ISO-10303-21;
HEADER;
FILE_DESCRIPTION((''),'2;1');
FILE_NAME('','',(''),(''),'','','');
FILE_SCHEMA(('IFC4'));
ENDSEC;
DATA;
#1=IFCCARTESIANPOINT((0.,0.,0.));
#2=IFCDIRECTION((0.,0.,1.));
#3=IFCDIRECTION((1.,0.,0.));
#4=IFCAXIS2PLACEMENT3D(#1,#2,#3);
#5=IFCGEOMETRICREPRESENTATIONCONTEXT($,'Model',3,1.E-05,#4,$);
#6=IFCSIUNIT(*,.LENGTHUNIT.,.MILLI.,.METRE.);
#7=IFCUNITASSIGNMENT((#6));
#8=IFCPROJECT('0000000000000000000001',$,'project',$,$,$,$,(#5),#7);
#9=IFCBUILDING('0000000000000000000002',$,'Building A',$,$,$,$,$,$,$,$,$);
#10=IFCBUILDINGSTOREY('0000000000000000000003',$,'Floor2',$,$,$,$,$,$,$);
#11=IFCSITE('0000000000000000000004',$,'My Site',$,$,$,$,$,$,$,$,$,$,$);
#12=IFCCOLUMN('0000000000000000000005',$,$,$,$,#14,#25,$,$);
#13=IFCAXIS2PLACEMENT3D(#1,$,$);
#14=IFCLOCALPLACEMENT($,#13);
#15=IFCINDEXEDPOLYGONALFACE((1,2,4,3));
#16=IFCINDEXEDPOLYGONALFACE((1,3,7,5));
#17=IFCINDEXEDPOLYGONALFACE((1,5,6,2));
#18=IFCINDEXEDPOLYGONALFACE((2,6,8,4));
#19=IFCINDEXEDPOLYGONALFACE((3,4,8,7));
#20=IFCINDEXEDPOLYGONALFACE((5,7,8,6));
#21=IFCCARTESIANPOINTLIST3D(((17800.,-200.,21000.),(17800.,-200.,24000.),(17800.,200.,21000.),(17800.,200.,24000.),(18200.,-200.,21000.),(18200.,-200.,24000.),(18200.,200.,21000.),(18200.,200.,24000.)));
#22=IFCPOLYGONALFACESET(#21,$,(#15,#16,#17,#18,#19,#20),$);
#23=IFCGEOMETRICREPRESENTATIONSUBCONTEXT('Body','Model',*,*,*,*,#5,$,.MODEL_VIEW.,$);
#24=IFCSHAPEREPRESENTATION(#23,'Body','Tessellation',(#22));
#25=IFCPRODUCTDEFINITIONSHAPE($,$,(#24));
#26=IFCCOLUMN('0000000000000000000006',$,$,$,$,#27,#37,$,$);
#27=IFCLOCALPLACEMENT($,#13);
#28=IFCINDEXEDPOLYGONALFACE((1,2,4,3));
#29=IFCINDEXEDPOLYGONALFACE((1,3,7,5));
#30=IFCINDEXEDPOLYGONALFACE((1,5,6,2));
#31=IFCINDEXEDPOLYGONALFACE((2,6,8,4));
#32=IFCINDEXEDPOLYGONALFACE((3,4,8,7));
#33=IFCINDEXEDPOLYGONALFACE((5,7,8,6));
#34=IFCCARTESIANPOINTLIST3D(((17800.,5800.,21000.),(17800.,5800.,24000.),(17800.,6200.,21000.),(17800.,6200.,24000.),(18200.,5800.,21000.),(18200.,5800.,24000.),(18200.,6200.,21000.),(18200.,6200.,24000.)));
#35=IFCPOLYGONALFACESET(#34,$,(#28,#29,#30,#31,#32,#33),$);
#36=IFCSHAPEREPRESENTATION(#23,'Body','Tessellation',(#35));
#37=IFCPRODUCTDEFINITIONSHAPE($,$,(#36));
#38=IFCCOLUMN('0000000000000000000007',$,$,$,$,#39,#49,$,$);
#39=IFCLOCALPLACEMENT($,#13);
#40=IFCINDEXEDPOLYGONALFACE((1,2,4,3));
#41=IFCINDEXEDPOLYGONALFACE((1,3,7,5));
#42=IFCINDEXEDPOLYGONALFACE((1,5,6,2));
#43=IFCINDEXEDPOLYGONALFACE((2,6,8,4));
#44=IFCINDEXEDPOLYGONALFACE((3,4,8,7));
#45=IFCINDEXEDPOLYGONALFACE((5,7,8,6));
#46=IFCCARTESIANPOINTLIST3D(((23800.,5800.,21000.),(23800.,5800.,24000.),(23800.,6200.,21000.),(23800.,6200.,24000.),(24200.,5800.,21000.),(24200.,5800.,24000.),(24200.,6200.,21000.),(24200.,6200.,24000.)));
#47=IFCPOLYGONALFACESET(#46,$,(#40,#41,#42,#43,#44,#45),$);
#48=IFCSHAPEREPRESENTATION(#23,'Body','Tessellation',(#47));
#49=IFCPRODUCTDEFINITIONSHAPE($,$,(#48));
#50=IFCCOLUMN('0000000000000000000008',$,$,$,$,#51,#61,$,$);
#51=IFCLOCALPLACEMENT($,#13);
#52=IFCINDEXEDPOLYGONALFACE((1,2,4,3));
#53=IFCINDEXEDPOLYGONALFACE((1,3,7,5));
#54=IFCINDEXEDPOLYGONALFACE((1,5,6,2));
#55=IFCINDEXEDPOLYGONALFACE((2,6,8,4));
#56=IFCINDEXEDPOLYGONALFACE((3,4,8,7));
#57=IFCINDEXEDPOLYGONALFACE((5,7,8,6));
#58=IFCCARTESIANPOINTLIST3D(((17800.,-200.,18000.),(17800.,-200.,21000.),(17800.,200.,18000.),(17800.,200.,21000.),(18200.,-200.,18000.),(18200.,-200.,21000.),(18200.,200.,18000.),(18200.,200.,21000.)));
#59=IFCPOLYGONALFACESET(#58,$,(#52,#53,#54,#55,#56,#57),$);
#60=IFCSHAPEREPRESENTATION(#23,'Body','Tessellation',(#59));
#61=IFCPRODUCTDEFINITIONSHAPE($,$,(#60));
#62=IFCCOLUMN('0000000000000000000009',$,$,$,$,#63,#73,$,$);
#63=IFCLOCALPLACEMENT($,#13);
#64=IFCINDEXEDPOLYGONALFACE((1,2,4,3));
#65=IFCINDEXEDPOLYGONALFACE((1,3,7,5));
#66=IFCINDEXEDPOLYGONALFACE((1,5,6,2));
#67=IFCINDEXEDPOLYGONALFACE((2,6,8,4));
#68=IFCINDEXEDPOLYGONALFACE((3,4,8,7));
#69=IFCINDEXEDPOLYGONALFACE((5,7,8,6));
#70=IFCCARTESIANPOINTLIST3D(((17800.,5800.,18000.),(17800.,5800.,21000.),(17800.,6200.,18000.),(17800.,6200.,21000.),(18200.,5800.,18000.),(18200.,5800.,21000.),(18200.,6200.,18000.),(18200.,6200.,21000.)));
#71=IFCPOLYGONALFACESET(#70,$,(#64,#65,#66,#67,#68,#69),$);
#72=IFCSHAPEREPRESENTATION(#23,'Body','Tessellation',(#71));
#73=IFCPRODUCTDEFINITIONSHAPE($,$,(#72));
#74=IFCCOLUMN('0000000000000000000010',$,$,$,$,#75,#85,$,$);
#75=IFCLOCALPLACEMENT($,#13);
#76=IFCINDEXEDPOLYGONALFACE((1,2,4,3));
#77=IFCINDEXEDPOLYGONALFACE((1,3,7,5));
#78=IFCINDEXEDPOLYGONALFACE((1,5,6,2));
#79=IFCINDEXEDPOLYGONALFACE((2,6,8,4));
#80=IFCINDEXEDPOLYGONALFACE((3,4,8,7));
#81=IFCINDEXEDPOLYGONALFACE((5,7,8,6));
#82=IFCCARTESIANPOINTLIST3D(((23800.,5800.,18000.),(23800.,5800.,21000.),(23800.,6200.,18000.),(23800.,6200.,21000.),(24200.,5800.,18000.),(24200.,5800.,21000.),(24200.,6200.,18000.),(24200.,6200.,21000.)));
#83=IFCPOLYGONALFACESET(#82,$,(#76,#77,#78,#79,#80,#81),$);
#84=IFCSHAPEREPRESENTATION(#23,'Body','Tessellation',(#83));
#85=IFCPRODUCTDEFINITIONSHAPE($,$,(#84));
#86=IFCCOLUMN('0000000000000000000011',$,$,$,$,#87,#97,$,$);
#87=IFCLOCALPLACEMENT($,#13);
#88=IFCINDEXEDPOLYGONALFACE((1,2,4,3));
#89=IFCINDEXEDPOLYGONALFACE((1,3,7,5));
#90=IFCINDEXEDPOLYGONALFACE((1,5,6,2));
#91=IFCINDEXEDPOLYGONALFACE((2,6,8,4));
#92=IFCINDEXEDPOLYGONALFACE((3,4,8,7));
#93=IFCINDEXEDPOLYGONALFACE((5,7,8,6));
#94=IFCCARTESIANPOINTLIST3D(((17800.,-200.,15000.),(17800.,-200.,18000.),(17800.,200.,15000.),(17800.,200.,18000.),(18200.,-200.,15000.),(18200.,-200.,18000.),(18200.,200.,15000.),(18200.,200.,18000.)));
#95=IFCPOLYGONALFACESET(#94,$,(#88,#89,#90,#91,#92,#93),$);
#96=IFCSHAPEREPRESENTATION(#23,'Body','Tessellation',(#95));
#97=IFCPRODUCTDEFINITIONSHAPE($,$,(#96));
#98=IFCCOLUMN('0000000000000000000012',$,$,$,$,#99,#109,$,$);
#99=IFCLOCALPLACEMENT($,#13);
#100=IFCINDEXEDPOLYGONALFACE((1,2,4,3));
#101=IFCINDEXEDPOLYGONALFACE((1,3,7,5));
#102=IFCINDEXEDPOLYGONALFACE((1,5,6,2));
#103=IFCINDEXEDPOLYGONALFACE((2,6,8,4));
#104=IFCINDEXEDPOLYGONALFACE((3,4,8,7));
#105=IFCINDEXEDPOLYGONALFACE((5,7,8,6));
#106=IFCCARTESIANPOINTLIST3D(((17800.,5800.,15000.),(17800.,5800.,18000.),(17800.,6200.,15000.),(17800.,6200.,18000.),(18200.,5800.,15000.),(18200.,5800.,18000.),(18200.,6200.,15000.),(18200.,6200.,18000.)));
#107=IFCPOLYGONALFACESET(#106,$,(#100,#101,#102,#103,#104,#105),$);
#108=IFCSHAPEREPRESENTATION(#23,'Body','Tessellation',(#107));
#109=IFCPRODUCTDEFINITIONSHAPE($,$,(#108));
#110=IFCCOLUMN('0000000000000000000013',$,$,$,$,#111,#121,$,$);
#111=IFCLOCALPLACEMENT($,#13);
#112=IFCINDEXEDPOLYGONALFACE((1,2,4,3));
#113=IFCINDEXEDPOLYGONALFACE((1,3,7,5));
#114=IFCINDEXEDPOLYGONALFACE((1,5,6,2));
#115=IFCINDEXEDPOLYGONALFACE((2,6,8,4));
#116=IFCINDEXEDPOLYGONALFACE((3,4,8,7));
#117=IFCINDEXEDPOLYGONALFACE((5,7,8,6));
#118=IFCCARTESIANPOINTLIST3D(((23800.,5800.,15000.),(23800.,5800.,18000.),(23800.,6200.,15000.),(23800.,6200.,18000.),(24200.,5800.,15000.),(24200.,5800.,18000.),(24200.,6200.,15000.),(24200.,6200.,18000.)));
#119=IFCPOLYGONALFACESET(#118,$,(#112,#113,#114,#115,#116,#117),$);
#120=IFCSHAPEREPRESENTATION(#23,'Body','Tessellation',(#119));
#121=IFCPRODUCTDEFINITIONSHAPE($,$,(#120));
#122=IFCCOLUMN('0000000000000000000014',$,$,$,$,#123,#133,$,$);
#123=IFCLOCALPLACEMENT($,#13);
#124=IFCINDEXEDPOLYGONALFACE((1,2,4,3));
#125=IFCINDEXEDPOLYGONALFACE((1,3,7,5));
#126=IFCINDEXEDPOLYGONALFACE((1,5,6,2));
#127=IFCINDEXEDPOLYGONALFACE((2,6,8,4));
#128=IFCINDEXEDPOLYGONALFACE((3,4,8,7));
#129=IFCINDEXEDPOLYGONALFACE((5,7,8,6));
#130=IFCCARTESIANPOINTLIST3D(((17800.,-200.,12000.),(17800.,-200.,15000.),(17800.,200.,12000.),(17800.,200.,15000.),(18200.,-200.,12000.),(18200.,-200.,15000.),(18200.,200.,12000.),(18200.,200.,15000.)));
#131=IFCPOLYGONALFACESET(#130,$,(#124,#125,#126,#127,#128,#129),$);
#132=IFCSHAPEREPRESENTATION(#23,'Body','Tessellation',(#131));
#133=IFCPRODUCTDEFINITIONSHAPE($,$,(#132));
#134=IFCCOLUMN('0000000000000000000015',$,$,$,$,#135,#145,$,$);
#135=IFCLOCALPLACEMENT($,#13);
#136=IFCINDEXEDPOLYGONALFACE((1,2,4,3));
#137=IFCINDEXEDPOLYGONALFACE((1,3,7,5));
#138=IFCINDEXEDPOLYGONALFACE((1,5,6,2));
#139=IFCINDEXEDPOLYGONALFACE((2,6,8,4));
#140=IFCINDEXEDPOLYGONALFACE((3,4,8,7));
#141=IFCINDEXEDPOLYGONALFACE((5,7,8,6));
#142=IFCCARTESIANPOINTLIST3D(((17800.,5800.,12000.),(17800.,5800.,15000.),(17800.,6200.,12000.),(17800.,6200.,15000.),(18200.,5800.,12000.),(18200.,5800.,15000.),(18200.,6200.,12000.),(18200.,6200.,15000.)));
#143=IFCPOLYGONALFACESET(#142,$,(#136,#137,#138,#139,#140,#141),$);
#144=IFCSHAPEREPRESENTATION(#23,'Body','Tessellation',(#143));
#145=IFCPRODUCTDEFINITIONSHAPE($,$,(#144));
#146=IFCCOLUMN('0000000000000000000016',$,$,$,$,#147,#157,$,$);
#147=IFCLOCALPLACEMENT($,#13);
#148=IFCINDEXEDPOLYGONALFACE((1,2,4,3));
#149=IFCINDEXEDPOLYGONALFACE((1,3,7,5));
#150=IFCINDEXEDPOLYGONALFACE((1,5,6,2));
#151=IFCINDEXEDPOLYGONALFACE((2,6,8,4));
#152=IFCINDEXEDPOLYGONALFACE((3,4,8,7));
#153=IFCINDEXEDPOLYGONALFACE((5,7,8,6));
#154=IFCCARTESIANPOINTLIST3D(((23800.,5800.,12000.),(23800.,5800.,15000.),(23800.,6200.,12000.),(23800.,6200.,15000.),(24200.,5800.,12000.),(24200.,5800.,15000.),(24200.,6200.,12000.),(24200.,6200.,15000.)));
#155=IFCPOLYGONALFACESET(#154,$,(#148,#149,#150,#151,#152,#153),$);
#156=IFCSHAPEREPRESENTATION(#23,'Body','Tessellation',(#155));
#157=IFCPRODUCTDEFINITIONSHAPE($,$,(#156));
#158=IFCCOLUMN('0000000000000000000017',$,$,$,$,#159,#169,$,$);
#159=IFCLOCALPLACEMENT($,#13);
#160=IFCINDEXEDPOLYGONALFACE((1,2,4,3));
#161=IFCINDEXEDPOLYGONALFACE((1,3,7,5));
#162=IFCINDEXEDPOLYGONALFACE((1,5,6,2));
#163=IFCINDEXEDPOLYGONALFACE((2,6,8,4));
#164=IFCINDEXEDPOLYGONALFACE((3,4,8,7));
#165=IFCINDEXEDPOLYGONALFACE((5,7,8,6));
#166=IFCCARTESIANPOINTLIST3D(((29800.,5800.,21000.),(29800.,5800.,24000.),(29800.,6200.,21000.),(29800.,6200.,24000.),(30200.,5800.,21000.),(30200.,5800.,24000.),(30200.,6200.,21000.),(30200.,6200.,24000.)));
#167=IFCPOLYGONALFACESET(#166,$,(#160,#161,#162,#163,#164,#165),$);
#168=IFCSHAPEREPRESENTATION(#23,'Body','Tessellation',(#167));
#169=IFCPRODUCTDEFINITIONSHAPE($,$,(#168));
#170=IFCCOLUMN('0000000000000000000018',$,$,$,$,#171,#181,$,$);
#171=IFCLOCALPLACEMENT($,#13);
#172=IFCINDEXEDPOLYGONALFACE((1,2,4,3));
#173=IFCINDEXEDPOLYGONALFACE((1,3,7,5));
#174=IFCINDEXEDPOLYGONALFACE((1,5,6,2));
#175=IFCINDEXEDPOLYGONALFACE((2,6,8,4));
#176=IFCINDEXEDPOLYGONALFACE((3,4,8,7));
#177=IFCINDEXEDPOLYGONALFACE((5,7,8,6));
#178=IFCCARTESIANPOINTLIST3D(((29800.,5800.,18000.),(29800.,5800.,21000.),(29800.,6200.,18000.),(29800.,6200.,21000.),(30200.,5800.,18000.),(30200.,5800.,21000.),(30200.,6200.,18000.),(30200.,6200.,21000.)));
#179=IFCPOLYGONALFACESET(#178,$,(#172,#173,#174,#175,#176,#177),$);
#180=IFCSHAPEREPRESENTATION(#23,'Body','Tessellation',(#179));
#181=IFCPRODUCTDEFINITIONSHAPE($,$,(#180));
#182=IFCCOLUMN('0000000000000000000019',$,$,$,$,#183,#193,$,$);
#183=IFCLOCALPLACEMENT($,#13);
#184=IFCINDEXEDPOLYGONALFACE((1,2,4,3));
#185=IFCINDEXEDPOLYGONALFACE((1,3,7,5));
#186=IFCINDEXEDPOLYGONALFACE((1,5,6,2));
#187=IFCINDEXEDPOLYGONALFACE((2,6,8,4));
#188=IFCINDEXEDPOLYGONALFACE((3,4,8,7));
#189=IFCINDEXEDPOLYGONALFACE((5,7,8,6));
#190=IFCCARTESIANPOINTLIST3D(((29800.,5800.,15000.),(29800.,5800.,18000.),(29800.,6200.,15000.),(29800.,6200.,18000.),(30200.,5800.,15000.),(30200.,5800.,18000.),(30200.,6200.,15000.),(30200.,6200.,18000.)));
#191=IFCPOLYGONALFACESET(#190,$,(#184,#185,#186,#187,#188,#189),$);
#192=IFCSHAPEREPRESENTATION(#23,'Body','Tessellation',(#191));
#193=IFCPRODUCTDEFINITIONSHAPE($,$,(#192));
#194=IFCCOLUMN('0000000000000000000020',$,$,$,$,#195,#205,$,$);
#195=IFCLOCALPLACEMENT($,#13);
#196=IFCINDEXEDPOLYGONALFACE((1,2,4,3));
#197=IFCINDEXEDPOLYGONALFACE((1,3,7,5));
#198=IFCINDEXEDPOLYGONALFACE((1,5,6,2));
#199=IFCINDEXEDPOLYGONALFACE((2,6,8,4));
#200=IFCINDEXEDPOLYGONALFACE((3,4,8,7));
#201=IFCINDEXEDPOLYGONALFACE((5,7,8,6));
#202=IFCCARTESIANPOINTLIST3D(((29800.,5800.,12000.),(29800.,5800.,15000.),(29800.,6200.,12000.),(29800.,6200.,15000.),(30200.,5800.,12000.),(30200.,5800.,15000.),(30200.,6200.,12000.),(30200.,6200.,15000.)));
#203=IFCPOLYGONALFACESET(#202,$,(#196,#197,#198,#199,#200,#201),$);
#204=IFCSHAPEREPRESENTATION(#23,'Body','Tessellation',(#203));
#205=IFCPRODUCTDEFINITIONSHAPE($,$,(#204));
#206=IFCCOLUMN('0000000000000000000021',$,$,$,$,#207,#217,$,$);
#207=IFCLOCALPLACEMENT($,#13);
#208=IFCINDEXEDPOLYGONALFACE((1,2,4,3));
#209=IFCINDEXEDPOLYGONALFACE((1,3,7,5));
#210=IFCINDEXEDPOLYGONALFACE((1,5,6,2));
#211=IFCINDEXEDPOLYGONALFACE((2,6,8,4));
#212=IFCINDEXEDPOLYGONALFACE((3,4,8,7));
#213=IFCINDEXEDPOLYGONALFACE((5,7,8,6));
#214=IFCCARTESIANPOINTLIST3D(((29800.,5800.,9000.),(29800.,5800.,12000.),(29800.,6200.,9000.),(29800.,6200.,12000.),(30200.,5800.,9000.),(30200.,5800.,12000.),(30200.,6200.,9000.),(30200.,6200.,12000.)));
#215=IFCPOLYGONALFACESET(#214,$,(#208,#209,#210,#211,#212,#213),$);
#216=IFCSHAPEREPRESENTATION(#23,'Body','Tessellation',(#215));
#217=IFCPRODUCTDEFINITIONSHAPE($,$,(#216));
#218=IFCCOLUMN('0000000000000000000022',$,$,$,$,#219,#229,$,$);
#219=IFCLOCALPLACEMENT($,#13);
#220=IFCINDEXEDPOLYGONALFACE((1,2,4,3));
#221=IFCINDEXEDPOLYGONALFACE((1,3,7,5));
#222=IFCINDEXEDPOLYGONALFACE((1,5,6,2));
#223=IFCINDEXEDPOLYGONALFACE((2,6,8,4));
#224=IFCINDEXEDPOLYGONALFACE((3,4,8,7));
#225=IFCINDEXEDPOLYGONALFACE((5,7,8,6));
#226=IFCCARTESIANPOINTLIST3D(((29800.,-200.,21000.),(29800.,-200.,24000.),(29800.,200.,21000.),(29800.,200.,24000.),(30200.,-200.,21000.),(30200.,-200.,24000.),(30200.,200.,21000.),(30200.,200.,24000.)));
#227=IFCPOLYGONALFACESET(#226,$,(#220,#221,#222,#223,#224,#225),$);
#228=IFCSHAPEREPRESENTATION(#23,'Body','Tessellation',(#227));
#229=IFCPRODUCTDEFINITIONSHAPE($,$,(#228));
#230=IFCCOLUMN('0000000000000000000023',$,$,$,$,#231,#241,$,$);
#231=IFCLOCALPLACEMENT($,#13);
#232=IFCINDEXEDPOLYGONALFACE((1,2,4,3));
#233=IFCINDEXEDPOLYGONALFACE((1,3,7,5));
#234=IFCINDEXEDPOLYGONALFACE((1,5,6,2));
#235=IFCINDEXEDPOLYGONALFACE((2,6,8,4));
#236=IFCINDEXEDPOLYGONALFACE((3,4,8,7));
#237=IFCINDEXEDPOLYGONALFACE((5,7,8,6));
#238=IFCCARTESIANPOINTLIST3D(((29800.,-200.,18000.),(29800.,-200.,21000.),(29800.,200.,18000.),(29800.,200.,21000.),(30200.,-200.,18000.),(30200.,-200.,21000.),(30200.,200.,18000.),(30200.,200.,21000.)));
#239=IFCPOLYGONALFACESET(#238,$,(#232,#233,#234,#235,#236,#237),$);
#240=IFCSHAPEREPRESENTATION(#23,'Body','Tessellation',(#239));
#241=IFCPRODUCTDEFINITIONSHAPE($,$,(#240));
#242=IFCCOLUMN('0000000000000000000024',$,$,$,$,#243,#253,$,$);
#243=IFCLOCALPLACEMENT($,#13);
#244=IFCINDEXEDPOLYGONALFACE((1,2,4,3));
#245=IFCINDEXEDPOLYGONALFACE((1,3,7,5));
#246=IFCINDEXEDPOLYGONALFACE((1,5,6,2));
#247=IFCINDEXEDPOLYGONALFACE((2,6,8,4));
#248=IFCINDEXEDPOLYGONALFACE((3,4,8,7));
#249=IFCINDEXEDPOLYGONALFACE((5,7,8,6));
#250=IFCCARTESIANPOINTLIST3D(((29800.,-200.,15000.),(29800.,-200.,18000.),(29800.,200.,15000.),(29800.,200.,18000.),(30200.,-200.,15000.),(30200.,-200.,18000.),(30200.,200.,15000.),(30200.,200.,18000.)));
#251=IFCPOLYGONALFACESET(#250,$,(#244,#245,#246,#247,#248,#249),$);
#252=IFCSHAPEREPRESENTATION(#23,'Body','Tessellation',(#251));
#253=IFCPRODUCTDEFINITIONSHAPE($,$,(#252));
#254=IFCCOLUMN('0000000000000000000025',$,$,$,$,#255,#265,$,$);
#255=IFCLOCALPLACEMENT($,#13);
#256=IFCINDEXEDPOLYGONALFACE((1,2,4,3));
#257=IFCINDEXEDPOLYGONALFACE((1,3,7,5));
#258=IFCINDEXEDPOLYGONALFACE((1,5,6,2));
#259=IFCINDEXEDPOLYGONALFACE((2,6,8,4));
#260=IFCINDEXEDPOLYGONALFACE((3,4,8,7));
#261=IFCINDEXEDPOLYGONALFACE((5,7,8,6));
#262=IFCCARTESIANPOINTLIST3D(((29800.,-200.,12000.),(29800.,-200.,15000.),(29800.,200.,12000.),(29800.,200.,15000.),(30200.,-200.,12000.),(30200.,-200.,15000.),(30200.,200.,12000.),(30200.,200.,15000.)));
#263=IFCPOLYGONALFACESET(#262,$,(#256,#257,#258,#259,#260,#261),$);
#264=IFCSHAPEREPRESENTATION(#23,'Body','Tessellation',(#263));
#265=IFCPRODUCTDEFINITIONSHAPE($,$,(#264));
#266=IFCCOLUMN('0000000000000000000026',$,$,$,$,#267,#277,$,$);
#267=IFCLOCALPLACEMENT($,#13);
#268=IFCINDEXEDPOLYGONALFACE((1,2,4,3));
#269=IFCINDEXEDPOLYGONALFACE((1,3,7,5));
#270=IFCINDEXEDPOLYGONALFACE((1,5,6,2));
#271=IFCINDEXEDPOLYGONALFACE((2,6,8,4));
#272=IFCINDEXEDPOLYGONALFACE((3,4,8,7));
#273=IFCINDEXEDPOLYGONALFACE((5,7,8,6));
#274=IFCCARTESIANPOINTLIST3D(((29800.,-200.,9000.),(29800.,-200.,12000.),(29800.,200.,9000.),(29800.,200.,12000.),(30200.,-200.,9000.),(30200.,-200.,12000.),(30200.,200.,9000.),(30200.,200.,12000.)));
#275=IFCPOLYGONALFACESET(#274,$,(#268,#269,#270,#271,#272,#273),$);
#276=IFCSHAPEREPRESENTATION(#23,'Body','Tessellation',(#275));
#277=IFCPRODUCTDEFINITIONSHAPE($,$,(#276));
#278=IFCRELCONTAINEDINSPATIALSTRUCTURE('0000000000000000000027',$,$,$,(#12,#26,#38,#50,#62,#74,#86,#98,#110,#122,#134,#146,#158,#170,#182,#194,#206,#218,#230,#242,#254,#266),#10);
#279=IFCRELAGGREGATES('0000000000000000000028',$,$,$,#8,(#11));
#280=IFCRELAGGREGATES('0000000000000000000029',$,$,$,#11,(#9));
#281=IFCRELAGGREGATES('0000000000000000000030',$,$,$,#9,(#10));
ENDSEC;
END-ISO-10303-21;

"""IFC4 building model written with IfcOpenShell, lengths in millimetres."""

from ifc_helpers import new_model, si_unit, frame, origin_with_axes, place, context, subcontext, project, spatial, line, indexed_curve, outline, extrude, element, save


model = new_model("IFC4")

# Units and contexts
model_context = context("Model", 3, precision=1e-05, world=origin_with_axes())
body_context = subcontext(model_context, "Body", "Model", "MODEL_VIEW")
ifc_project = project(units=[si_unit("LENGTHUNIT", "METRE", prefix="MILLI")], contexts=[model_context])

# Site, building, storey
site = spatial("IfcSite", under=ifc_project, Name="My Site")
building = spatial("IfcBuilding", under=site, Name="Building A")
storey = spatial("IfcBuildingStorey", under=building, Name="Floor2")

# Columns
for number, where, z_axis, x_axis in (
    (1, (18000.0, 0.0, 21000.0), (0.0, 0.0, 1.0), (1.0, 0.0, 0.0)),
    (2, (18000.0, 6000.0, 21000.0), (0.0, 0.0, 1.0), (1.0, 0.0, 0.0)),
    (3, (24000.0, 6000.0, 21000.0), (0.0, 0.0, 1.0), (1.0, 0.0, 0.0)),
    (4, (18000.0, 0.0, 18000.0), (0.0, 0.0, 1.0), (1.0, 0.0, 0.0)),
    (5, (18000.0, 6000.0, 18000.0), (0.0, 0.0, 1.0), (1.0, 0.0, 0.0)),
    (6, (24000.0, 6000.0, 18000.0), (0.0, 0.0, 1.0), (1.0, 0.0, 0.0)),
    (7, (18000.0, 0.0, 15000.0), (0.0, 0.0, 1.0), (1.0, 0.0, 0.0)),
    (8, (18000.0, 6000.0, 15000.0), (0.0, 0.0, 1.0), (1.0, 0.0, 0.0)),
    (9, (24000.0, 6000.0, 15000.0), (0.0, 0.0, 1.0), (1.0, 0.0, 0.0)),
    (10, (18000.0, 0.0, 12000.0), (0.0, 0.0, 1.0), (1.0, 0.0, 0.0)),
    (11, (18000.0, 6000.0, 12000.0), (0.0, 0.0, 1.0), (1.0, 0.0, 0.0)),
    (12, (24000.0, 6000.0, 12000.0), (0.0, 0.0, 1.0), (1.0, 0.0, 0.0)),
    (13, (30000.0, 6000.0, 21000.0), (0.0, 0.0, 1.0), (1.0, 0.0, 0.0)),
    (14, (30000.0, 6000.0, 18000.0), (0.0, 0.0, 1.0), (1.0, 0.0, 0.0)),
    (15, (30000.0, 6000.0, 15000.0), (0.0, 0.0, 1.0), (1.0, 0.0, 0.0)),
    (16, (30000.0, 6000.0, 12000.0), (0.0, 0.0, 1.0), (1.0, 0.0, 0.0)),
    (17, (30000.0, 6000.0, 9000.0), (0.0, 0.0, 1.0), (1.0, 0.0, 0.0)),
    (18, (30000.0, 0.0, 21000.0), (0.0, 0.0, 1.0), (1.0, 0.0, 0.0)),
    (19, (30000.0, 0.0, 18000.0), (0.0, 0.0, 1.0), (1.0, 0.0, 0.0)),
    (20, (30000.0, 0.0, 15000.0), (0.0, 0.0, 1.0), (1.0, 0.0, 0.0)),
    (21, (30000.0, 0.0, 12000.0), (0.0, 0.0, 1.0), (1.0, 0.0, 0.0)),
    (22, (30000.0, 0.0, 9000.0), (0.0, 0.0, 1.0), (1.0, 0.0, 0.0)),
):
    element("IfcColumn", number, at=place(None, frame(where, z_axis=z_axis, x_axis=x_axis)), inside=storey, context=body_context, shape_type="SweptSolid", body=[
        extrude(outline(indexed_curve([(-200.0, -200.0), (200.0, -200.0), (200.0, 200.0), (-200.0, 200.0)], segments=[line(1, 2, 3, 4, 1)])), origin_with_axes(), (0.0, 0.0, 1.0), 3000.0),
    ])

save(model, "model.ifc")
